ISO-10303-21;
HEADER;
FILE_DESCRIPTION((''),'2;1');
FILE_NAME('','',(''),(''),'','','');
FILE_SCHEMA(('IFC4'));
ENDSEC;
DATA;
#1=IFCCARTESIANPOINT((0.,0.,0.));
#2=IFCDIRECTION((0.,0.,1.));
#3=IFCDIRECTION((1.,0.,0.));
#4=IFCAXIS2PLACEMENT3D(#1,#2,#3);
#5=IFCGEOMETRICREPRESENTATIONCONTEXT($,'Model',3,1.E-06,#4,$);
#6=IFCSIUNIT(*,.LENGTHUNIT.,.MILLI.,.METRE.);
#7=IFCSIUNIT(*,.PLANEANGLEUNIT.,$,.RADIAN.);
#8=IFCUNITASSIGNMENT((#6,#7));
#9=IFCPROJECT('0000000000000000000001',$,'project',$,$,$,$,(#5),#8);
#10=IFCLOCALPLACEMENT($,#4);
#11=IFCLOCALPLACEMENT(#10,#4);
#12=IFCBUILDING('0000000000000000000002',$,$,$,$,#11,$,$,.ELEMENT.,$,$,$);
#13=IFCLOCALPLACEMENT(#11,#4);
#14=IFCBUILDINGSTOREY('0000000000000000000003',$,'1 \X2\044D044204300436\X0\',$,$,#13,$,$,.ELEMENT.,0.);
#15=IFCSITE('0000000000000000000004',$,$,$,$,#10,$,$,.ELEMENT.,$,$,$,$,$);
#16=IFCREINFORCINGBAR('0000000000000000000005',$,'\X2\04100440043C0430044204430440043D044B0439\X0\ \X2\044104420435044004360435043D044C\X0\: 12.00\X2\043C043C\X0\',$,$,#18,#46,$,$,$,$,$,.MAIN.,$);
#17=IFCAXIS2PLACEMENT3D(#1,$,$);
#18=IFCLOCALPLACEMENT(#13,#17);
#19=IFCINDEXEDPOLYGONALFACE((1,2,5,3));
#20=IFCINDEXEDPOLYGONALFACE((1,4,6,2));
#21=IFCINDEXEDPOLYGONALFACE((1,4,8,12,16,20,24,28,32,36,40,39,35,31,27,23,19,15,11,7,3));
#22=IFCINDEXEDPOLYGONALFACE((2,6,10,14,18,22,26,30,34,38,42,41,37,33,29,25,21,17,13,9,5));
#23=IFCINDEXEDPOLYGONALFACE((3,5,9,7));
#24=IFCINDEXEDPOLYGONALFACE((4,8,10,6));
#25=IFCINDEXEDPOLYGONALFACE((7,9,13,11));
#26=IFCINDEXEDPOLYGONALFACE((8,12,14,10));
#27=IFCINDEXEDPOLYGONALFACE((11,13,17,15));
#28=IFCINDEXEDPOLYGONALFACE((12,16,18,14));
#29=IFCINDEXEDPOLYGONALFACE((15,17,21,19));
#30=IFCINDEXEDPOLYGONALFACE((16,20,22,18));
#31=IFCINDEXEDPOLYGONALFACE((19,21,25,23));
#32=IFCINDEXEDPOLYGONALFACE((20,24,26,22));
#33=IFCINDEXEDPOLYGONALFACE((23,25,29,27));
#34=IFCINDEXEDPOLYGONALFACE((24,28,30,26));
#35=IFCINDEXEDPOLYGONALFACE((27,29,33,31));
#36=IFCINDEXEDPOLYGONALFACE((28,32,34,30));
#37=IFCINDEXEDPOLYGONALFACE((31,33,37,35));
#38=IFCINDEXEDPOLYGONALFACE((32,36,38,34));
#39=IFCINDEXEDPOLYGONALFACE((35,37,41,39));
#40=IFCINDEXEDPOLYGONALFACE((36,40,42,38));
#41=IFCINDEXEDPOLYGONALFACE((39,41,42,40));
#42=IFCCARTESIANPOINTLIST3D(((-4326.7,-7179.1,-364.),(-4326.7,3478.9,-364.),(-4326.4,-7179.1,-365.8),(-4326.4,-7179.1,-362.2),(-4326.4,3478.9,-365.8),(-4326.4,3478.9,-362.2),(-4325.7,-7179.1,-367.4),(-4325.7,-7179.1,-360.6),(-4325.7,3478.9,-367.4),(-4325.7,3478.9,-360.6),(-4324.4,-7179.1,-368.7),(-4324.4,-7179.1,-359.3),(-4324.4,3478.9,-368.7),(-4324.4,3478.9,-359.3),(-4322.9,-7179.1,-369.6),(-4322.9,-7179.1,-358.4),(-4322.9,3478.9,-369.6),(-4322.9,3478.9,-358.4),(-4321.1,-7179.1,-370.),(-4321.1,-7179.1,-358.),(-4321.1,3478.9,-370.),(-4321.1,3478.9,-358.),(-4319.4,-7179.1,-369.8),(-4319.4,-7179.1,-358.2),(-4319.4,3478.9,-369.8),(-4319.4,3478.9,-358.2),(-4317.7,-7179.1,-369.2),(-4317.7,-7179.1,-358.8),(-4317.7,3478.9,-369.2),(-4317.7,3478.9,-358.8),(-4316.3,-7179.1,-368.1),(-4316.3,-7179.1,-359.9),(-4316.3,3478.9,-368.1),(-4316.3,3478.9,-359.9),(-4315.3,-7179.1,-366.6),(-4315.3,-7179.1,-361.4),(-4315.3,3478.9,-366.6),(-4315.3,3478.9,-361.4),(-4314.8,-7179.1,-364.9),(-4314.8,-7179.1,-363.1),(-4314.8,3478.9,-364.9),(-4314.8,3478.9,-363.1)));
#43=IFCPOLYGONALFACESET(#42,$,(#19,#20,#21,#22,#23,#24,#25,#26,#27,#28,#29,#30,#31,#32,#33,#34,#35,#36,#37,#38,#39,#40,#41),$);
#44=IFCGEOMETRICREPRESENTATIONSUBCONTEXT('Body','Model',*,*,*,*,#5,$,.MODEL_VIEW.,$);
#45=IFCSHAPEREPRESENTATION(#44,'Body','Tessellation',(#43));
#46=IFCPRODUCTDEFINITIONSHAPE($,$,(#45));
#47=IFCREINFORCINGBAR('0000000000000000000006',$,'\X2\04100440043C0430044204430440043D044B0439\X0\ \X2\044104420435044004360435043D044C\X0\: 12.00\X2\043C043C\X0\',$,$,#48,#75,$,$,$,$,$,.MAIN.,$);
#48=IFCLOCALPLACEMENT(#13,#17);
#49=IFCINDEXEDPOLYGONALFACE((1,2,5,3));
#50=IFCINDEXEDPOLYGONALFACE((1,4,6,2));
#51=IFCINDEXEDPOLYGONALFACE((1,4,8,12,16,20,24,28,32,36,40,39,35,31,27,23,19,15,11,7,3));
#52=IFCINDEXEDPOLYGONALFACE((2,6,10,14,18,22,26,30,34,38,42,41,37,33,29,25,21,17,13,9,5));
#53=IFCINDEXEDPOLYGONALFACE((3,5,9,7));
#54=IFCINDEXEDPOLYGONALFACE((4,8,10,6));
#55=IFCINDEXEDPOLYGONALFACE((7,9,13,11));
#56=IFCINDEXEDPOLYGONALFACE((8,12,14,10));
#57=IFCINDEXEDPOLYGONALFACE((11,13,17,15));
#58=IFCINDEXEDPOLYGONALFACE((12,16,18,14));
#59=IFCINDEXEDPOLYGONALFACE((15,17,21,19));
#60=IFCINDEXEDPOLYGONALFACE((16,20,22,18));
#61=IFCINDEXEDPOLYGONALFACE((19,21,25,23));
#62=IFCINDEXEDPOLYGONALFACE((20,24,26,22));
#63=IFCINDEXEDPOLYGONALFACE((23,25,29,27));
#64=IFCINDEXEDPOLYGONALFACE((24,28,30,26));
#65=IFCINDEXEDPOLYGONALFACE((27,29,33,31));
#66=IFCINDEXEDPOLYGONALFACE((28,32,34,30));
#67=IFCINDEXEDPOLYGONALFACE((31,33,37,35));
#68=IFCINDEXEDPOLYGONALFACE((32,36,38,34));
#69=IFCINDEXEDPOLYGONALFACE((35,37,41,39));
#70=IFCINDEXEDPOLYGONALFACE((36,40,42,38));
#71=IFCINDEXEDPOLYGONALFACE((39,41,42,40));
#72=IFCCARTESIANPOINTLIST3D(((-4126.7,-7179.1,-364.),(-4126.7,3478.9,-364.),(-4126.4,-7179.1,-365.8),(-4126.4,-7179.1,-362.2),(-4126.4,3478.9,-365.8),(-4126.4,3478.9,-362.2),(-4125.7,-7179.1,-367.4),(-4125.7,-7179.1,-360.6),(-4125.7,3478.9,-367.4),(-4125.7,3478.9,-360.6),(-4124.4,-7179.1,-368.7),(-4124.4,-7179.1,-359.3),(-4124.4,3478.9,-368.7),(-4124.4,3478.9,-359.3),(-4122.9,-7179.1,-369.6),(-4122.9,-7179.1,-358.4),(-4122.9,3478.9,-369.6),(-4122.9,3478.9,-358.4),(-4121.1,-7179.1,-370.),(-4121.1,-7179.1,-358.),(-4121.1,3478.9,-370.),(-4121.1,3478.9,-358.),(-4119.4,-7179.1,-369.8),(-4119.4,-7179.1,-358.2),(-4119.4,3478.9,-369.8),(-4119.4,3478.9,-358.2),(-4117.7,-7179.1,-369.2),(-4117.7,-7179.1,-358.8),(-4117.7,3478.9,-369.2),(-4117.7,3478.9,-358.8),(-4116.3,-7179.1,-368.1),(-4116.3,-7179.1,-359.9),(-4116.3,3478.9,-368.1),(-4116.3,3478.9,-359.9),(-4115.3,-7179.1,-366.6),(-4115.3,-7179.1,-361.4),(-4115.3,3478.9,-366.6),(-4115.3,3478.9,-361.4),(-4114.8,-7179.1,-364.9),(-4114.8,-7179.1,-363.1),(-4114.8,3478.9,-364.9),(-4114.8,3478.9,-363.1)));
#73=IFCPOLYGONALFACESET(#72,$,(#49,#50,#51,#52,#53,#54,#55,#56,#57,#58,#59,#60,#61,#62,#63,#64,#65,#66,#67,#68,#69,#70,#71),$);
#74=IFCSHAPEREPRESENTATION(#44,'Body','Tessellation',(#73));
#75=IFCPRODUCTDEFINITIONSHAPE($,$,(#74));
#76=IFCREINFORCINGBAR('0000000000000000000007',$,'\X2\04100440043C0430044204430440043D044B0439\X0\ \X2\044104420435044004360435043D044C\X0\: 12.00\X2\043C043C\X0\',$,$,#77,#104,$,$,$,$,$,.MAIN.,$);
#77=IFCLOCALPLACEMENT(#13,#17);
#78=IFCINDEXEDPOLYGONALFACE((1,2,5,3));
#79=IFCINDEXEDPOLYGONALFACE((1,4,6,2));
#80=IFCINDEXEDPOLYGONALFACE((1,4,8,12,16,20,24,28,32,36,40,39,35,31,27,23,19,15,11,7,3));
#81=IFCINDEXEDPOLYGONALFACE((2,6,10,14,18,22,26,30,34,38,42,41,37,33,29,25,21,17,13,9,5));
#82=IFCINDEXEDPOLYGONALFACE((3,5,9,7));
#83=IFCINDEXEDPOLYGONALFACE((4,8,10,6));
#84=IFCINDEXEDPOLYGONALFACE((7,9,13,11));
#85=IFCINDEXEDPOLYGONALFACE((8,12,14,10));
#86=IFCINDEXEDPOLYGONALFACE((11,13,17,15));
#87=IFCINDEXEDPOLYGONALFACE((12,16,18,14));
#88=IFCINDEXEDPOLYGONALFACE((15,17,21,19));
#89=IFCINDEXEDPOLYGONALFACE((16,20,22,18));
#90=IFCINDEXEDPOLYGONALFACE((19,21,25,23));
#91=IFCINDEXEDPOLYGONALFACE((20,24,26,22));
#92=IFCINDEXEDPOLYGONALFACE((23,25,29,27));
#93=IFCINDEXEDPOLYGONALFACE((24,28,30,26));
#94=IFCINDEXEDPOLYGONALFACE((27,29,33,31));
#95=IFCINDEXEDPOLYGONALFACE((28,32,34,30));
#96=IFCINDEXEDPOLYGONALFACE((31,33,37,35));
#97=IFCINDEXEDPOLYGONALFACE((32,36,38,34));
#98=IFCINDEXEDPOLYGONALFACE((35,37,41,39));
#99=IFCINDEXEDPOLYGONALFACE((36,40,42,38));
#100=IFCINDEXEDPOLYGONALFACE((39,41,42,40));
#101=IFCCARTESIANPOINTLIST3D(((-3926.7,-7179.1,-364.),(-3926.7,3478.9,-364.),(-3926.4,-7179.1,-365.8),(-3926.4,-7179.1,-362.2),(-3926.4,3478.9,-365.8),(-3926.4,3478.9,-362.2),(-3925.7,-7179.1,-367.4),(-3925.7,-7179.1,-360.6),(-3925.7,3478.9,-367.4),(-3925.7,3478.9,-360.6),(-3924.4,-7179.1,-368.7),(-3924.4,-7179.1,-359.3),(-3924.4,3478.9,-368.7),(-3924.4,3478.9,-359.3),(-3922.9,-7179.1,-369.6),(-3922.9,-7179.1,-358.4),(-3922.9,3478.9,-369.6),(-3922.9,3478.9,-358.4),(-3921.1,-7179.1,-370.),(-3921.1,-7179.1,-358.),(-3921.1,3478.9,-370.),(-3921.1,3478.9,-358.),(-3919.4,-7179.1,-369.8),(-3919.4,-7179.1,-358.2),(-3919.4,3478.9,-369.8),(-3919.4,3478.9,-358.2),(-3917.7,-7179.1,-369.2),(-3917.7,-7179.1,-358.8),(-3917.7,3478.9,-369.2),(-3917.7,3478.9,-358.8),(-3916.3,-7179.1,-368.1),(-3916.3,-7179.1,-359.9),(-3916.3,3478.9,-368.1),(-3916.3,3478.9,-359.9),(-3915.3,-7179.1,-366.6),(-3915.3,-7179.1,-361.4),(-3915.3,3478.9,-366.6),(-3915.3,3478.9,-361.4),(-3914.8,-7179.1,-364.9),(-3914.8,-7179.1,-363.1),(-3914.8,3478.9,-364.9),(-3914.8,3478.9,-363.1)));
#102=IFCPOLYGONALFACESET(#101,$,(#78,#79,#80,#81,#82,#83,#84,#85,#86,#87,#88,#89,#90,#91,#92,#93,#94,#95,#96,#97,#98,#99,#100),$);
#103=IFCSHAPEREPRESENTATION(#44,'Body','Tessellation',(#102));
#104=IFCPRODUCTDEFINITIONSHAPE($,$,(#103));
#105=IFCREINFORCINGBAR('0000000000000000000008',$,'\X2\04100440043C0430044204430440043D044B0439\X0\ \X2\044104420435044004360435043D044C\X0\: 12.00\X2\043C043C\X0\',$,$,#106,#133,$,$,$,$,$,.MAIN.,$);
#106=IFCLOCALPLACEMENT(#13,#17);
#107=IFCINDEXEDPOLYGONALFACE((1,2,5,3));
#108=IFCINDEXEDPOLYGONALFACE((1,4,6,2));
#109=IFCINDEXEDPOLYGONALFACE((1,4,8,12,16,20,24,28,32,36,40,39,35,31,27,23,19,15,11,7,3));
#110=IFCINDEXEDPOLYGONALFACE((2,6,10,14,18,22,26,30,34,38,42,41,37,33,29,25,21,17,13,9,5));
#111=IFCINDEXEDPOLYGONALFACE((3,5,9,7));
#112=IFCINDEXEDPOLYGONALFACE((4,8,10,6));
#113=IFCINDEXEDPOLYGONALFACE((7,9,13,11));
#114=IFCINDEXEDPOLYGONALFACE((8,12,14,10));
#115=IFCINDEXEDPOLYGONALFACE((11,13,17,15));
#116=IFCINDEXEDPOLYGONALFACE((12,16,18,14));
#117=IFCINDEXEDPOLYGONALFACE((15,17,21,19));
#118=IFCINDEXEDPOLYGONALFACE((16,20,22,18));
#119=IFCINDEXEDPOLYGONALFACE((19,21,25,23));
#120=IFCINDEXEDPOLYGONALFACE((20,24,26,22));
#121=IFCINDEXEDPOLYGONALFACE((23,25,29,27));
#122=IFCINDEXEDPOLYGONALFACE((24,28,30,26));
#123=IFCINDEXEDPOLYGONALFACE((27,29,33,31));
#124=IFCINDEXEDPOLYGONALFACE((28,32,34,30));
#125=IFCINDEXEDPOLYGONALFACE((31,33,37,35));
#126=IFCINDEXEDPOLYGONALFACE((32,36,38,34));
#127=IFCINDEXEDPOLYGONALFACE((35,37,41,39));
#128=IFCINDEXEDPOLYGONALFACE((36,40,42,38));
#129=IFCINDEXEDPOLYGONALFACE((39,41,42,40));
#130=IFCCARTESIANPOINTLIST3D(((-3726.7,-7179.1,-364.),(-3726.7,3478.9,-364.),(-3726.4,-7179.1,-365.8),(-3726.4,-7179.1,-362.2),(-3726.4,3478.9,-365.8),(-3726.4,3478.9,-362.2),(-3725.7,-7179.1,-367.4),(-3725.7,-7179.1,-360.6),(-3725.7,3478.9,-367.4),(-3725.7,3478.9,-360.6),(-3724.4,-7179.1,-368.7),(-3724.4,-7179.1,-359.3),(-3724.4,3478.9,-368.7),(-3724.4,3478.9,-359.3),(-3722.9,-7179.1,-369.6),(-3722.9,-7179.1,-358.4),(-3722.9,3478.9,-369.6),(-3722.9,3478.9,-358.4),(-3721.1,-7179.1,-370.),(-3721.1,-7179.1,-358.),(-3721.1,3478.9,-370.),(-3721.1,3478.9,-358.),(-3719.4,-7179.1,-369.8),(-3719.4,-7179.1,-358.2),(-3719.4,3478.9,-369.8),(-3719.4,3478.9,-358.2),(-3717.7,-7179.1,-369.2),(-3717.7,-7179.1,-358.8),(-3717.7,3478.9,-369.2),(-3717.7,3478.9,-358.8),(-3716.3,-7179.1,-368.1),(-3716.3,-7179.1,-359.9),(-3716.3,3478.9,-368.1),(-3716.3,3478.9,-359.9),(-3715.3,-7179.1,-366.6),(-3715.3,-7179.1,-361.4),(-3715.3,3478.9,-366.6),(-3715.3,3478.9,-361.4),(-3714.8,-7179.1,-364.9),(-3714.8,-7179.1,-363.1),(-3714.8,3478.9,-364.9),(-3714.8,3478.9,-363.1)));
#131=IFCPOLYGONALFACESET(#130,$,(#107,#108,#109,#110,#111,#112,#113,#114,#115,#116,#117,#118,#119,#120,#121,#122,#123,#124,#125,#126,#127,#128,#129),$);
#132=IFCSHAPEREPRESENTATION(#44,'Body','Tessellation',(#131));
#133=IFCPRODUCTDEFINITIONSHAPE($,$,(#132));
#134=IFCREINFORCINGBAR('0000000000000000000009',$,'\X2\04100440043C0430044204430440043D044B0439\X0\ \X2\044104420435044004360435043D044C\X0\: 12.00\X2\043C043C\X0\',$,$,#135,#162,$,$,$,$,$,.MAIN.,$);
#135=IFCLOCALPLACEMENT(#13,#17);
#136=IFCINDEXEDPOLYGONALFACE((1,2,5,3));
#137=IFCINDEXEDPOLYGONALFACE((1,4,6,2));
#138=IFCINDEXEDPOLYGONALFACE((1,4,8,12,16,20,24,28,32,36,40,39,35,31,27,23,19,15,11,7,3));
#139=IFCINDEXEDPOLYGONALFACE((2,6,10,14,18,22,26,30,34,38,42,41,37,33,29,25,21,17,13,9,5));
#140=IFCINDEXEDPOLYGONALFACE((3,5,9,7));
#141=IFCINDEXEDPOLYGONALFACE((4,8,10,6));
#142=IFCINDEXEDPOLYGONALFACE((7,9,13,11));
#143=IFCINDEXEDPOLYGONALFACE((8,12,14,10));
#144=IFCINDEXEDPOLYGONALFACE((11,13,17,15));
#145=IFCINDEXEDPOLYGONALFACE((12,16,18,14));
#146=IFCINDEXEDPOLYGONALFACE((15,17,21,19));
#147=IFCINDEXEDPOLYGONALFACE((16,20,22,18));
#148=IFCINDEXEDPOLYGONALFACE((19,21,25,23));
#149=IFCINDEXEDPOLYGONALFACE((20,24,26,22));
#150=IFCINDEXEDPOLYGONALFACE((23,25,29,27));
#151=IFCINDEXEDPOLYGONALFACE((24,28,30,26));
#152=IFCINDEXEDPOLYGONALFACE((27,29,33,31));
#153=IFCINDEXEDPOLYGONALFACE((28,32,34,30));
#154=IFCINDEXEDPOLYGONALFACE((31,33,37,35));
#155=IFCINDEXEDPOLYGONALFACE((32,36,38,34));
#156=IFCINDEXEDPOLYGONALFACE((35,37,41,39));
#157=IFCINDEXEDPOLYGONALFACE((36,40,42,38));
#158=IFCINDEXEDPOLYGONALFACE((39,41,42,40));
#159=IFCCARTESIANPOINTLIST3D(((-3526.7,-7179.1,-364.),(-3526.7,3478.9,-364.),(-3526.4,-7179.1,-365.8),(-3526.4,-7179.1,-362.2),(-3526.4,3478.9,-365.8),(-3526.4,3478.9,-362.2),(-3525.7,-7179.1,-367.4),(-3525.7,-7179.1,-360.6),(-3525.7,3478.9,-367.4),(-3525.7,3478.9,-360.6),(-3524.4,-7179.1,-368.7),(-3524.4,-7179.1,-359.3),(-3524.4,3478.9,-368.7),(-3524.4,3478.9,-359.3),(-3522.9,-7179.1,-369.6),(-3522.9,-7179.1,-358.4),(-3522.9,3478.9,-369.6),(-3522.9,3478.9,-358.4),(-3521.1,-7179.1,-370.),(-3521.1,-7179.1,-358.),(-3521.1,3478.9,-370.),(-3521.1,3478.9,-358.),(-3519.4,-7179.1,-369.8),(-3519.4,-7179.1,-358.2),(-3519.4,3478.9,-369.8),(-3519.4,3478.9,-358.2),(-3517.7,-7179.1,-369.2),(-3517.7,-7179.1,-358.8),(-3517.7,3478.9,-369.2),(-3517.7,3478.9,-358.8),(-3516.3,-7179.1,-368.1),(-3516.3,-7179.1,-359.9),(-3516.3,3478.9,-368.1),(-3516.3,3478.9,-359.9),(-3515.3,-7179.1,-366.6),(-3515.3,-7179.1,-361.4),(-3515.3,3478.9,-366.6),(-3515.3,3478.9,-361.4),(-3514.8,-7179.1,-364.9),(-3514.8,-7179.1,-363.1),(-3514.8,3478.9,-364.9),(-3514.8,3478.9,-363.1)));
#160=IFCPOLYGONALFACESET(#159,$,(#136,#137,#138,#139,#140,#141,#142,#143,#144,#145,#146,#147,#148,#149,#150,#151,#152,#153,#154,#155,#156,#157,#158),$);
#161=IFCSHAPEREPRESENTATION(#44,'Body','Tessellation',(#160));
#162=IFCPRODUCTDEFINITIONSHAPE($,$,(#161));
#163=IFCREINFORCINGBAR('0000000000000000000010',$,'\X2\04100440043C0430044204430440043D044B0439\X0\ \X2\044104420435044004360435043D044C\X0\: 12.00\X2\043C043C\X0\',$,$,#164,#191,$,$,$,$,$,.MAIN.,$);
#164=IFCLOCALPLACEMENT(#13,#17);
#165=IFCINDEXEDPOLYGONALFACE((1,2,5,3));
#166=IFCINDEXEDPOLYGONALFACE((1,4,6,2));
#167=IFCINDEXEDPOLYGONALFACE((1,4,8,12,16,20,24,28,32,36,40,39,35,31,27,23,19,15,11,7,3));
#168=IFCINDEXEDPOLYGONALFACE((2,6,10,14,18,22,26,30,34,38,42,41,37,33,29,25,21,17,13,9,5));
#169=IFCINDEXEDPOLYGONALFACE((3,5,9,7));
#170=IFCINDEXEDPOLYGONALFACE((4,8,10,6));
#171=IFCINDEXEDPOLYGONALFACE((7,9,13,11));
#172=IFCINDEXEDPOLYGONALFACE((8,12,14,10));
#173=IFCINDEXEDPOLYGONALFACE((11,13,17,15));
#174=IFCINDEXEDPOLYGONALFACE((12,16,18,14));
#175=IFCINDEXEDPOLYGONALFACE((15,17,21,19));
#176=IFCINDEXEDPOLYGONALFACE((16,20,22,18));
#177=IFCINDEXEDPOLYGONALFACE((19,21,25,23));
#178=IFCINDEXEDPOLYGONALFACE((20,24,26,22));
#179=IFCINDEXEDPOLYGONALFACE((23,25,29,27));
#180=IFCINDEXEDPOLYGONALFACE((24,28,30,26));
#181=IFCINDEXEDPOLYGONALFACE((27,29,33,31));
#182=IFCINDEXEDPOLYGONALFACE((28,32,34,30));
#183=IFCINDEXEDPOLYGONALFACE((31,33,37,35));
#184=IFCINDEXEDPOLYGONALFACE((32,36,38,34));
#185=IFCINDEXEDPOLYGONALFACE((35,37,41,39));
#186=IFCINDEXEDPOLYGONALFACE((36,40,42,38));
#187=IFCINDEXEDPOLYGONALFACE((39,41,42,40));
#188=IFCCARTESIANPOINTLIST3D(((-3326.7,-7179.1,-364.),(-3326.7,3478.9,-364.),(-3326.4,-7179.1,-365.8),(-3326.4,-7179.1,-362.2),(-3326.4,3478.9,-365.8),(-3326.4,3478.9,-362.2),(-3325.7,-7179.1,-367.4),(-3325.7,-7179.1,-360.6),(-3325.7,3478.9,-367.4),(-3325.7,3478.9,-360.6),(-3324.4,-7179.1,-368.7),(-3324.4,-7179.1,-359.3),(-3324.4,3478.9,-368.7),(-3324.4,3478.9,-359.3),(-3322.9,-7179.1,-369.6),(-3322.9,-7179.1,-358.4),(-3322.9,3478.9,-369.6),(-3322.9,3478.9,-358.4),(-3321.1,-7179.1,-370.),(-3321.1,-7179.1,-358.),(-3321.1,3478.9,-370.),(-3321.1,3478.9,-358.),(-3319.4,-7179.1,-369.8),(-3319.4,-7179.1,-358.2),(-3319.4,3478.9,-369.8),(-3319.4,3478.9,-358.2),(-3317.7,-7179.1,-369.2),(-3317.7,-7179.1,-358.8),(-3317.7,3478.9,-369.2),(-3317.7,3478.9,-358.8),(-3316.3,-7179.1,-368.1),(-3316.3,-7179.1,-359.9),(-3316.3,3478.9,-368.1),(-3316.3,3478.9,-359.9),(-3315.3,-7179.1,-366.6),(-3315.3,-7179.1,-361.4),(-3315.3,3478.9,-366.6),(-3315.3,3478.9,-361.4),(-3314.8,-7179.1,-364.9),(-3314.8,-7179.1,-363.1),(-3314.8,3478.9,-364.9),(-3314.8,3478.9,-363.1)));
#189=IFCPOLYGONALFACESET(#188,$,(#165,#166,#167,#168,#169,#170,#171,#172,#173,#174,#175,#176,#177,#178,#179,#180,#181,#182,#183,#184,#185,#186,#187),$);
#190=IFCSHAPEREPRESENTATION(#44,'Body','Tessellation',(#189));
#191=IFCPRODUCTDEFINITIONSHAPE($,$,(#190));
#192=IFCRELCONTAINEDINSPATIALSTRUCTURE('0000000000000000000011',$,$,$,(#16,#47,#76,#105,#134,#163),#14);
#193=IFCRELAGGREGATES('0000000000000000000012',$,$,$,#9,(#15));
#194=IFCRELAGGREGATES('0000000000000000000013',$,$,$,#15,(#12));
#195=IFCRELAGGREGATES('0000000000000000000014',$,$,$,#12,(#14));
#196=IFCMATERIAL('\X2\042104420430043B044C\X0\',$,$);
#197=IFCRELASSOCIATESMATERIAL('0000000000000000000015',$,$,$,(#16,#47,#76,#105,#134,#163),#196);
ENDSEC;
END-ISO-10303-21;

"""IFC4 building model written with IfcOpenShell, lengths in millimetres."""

from ifc_helpers import new_model, entity, si_unit, origin_with_axes, place, context, subcontext, project, spatial, source, transform, mapped, material, element, save


model = new_model("IFC4")

# Units and contexts
model_context = context("Model", 3, precision=1e-06, world=origin_with_axes())
body_context = subcontext(model_context, "Body", "Model", "MODEL_VIEW")
ifc_project = project(units=[si_unit("LENGTHUNIT", "METRE", prefix="MILLI"), si_unit("PLANEANGLEUNIT", "RADIAN")], contexts=[model_context])

# Site, building, storey
site_placement = place(None, origin_with_axes())
site = spatial("IfcSite", under=ifc_project, at=site_placement, CompositionType="ELEMENT")
building_placement = place(site_placement, origin_with_axes())
building = spatial("IfcBuilding", under=site, at=building_placement, CompositionType="ELEMENT")
storey_placement = place(building_placement, origin_with_axes())
storey = spatial("IfcBuildingStorey", under=building, at=storey_placement, Name="1 этаж", CompositionType="ELEMENT", Elevation=0.0)

# Reinforcing bars
ifc_material = material(Name="Сталь")
shared_shape_1 = source(origin_with_axes(), body_context, "Body", "AdvancedSweptSolid", [
    entity("IfcSweptDiskSolid", entity("IfcIndexedPolyCurve", entity("IfcCartesianPointList3D", [[0.0, 0.0, 0.0], [10658.0, 0.0, 0.0]]), [entity("IfcLineIndex", [1, 2])]), 6.0),
])
reinforcing_bar_1_placement = place(storey_placement, origin_with_axes())
element("IfcReinforcingBar", 1, at=reinforcing_bar_1_placement, inside=storey, material=ifc_material, Name="Арматурный стержень: 12.00мм", PredefinedType="MAIN", context=body_context, shape_type="MappedRepresentation", body=[
    mapped(shared_shape_1, transform((-4320.7, -7179.1, -364.0), x_axis=(0.0, 1.0, 0.0), y_axis=(-1.0, 0.0, 0.0), z_axis=(0.0, 0.0, 1.0), scale=1.0)),
])
reinforcing_bar_2_placement = place(storey_placement, origin_with_axes())
element("IfcReinforcingBar", 2, at=reinforcing_bar_2_placement, inside=storey, material=ifc_material, Name="Арматурный стержень: 12.00мм", PredefinedType="MAIN", context=body_context, shape_type="MappedRepresentation", body=[
    mapped(shared_shape_1, transform((-4120.7, -7179.1, -364.0), x_axis=(0.0, 1.0, 0.0), y_axis=(-1.0, 0.0, 0.0), z_axis=(0.0, 0.0, 1.0), scale=1.0)),
])
reinforcing_bar_3_placement = place(storey_placement, origin_with_axes())
element("IfcReinforcingBar", 3, at=reinforcing_bar_3_placement, inside=storey, material=ifc_material, Name="Арматурный стержень: 12.00мм", PredefinedType="MAIN", context=body_context, shape_type="MappedRepresentation", body=[
    mapped(shared_shape_1, transform((-3920.7, -7179.1, -364.0), x_axis=(0.0, 1.0, 0.0), y_axis=(-1.0, 0.0, 0.0), z_axis=(0.0, 0.0, 1.0), scale=1.0)),
])
reinforcing_bar_4_placement = place(storey_placement, origin_with_axes())
element("IfcReinforcingBar", 4, at=reinforcing_bar_4_placement, inside=storey, material=ifc_material, Name="Арматурный стержень: 12.00мм", PredefinedType="MAIN", context=body_context, shape_type="MappedRepresentation", body=[
    mapped(shared_shape_1, transform((-3720.7, -7179.1, -364.0), x_axis=(0.0, 1.0, 0.0), y_axis=(-1.0, 0.0, 0.0), z_axis=(0.0, 0.0, 1.0), scale=1.0)),
])
reinforcing_bar_5_placement = place(storey_placement, origin_with_axes())
element("IfcReinforcingBar", 5, at=reinforcing_bar_5_placement, inside=storey, material=ifc_material, Name="Арматурный стержень: 12.00мм", PredefinedType="MAIN", context=body_context, shape_type="MappedRepresentation", body=[
    mapped(shared_shape_1, transform((-3520.7, -7179.1, -364.0), x_axis=(0.0, 1.0, 0.0), y_axis=(-1.0, 0.0, 0.0), z_axis=(0.0, 0.0, 1.0), scale=1.0)),
])
reinforcing_bar_6_placement = place(storey_placement, origin_with_axes())
element("IfcReinforcingBar", 6, at=reinforcing_bar_6_placement, inside=storey, material=ifc_material, Name="Арматурный стержень: 12.00мм", PredefinedType="MAIN", context=body_context, shape_type="MappedRepresentation", body=[
    mapped(shared_shape_1, transform((-3320.7, -7179.1, -364.0), x_axis=(0.0, 1.0, 0.0), y_axis=(-1.0, 0.0, 0.0), z_axis=(0.0, 0.0, 1.0), scale=1.0)),
])

save(model, "model.ifc")
